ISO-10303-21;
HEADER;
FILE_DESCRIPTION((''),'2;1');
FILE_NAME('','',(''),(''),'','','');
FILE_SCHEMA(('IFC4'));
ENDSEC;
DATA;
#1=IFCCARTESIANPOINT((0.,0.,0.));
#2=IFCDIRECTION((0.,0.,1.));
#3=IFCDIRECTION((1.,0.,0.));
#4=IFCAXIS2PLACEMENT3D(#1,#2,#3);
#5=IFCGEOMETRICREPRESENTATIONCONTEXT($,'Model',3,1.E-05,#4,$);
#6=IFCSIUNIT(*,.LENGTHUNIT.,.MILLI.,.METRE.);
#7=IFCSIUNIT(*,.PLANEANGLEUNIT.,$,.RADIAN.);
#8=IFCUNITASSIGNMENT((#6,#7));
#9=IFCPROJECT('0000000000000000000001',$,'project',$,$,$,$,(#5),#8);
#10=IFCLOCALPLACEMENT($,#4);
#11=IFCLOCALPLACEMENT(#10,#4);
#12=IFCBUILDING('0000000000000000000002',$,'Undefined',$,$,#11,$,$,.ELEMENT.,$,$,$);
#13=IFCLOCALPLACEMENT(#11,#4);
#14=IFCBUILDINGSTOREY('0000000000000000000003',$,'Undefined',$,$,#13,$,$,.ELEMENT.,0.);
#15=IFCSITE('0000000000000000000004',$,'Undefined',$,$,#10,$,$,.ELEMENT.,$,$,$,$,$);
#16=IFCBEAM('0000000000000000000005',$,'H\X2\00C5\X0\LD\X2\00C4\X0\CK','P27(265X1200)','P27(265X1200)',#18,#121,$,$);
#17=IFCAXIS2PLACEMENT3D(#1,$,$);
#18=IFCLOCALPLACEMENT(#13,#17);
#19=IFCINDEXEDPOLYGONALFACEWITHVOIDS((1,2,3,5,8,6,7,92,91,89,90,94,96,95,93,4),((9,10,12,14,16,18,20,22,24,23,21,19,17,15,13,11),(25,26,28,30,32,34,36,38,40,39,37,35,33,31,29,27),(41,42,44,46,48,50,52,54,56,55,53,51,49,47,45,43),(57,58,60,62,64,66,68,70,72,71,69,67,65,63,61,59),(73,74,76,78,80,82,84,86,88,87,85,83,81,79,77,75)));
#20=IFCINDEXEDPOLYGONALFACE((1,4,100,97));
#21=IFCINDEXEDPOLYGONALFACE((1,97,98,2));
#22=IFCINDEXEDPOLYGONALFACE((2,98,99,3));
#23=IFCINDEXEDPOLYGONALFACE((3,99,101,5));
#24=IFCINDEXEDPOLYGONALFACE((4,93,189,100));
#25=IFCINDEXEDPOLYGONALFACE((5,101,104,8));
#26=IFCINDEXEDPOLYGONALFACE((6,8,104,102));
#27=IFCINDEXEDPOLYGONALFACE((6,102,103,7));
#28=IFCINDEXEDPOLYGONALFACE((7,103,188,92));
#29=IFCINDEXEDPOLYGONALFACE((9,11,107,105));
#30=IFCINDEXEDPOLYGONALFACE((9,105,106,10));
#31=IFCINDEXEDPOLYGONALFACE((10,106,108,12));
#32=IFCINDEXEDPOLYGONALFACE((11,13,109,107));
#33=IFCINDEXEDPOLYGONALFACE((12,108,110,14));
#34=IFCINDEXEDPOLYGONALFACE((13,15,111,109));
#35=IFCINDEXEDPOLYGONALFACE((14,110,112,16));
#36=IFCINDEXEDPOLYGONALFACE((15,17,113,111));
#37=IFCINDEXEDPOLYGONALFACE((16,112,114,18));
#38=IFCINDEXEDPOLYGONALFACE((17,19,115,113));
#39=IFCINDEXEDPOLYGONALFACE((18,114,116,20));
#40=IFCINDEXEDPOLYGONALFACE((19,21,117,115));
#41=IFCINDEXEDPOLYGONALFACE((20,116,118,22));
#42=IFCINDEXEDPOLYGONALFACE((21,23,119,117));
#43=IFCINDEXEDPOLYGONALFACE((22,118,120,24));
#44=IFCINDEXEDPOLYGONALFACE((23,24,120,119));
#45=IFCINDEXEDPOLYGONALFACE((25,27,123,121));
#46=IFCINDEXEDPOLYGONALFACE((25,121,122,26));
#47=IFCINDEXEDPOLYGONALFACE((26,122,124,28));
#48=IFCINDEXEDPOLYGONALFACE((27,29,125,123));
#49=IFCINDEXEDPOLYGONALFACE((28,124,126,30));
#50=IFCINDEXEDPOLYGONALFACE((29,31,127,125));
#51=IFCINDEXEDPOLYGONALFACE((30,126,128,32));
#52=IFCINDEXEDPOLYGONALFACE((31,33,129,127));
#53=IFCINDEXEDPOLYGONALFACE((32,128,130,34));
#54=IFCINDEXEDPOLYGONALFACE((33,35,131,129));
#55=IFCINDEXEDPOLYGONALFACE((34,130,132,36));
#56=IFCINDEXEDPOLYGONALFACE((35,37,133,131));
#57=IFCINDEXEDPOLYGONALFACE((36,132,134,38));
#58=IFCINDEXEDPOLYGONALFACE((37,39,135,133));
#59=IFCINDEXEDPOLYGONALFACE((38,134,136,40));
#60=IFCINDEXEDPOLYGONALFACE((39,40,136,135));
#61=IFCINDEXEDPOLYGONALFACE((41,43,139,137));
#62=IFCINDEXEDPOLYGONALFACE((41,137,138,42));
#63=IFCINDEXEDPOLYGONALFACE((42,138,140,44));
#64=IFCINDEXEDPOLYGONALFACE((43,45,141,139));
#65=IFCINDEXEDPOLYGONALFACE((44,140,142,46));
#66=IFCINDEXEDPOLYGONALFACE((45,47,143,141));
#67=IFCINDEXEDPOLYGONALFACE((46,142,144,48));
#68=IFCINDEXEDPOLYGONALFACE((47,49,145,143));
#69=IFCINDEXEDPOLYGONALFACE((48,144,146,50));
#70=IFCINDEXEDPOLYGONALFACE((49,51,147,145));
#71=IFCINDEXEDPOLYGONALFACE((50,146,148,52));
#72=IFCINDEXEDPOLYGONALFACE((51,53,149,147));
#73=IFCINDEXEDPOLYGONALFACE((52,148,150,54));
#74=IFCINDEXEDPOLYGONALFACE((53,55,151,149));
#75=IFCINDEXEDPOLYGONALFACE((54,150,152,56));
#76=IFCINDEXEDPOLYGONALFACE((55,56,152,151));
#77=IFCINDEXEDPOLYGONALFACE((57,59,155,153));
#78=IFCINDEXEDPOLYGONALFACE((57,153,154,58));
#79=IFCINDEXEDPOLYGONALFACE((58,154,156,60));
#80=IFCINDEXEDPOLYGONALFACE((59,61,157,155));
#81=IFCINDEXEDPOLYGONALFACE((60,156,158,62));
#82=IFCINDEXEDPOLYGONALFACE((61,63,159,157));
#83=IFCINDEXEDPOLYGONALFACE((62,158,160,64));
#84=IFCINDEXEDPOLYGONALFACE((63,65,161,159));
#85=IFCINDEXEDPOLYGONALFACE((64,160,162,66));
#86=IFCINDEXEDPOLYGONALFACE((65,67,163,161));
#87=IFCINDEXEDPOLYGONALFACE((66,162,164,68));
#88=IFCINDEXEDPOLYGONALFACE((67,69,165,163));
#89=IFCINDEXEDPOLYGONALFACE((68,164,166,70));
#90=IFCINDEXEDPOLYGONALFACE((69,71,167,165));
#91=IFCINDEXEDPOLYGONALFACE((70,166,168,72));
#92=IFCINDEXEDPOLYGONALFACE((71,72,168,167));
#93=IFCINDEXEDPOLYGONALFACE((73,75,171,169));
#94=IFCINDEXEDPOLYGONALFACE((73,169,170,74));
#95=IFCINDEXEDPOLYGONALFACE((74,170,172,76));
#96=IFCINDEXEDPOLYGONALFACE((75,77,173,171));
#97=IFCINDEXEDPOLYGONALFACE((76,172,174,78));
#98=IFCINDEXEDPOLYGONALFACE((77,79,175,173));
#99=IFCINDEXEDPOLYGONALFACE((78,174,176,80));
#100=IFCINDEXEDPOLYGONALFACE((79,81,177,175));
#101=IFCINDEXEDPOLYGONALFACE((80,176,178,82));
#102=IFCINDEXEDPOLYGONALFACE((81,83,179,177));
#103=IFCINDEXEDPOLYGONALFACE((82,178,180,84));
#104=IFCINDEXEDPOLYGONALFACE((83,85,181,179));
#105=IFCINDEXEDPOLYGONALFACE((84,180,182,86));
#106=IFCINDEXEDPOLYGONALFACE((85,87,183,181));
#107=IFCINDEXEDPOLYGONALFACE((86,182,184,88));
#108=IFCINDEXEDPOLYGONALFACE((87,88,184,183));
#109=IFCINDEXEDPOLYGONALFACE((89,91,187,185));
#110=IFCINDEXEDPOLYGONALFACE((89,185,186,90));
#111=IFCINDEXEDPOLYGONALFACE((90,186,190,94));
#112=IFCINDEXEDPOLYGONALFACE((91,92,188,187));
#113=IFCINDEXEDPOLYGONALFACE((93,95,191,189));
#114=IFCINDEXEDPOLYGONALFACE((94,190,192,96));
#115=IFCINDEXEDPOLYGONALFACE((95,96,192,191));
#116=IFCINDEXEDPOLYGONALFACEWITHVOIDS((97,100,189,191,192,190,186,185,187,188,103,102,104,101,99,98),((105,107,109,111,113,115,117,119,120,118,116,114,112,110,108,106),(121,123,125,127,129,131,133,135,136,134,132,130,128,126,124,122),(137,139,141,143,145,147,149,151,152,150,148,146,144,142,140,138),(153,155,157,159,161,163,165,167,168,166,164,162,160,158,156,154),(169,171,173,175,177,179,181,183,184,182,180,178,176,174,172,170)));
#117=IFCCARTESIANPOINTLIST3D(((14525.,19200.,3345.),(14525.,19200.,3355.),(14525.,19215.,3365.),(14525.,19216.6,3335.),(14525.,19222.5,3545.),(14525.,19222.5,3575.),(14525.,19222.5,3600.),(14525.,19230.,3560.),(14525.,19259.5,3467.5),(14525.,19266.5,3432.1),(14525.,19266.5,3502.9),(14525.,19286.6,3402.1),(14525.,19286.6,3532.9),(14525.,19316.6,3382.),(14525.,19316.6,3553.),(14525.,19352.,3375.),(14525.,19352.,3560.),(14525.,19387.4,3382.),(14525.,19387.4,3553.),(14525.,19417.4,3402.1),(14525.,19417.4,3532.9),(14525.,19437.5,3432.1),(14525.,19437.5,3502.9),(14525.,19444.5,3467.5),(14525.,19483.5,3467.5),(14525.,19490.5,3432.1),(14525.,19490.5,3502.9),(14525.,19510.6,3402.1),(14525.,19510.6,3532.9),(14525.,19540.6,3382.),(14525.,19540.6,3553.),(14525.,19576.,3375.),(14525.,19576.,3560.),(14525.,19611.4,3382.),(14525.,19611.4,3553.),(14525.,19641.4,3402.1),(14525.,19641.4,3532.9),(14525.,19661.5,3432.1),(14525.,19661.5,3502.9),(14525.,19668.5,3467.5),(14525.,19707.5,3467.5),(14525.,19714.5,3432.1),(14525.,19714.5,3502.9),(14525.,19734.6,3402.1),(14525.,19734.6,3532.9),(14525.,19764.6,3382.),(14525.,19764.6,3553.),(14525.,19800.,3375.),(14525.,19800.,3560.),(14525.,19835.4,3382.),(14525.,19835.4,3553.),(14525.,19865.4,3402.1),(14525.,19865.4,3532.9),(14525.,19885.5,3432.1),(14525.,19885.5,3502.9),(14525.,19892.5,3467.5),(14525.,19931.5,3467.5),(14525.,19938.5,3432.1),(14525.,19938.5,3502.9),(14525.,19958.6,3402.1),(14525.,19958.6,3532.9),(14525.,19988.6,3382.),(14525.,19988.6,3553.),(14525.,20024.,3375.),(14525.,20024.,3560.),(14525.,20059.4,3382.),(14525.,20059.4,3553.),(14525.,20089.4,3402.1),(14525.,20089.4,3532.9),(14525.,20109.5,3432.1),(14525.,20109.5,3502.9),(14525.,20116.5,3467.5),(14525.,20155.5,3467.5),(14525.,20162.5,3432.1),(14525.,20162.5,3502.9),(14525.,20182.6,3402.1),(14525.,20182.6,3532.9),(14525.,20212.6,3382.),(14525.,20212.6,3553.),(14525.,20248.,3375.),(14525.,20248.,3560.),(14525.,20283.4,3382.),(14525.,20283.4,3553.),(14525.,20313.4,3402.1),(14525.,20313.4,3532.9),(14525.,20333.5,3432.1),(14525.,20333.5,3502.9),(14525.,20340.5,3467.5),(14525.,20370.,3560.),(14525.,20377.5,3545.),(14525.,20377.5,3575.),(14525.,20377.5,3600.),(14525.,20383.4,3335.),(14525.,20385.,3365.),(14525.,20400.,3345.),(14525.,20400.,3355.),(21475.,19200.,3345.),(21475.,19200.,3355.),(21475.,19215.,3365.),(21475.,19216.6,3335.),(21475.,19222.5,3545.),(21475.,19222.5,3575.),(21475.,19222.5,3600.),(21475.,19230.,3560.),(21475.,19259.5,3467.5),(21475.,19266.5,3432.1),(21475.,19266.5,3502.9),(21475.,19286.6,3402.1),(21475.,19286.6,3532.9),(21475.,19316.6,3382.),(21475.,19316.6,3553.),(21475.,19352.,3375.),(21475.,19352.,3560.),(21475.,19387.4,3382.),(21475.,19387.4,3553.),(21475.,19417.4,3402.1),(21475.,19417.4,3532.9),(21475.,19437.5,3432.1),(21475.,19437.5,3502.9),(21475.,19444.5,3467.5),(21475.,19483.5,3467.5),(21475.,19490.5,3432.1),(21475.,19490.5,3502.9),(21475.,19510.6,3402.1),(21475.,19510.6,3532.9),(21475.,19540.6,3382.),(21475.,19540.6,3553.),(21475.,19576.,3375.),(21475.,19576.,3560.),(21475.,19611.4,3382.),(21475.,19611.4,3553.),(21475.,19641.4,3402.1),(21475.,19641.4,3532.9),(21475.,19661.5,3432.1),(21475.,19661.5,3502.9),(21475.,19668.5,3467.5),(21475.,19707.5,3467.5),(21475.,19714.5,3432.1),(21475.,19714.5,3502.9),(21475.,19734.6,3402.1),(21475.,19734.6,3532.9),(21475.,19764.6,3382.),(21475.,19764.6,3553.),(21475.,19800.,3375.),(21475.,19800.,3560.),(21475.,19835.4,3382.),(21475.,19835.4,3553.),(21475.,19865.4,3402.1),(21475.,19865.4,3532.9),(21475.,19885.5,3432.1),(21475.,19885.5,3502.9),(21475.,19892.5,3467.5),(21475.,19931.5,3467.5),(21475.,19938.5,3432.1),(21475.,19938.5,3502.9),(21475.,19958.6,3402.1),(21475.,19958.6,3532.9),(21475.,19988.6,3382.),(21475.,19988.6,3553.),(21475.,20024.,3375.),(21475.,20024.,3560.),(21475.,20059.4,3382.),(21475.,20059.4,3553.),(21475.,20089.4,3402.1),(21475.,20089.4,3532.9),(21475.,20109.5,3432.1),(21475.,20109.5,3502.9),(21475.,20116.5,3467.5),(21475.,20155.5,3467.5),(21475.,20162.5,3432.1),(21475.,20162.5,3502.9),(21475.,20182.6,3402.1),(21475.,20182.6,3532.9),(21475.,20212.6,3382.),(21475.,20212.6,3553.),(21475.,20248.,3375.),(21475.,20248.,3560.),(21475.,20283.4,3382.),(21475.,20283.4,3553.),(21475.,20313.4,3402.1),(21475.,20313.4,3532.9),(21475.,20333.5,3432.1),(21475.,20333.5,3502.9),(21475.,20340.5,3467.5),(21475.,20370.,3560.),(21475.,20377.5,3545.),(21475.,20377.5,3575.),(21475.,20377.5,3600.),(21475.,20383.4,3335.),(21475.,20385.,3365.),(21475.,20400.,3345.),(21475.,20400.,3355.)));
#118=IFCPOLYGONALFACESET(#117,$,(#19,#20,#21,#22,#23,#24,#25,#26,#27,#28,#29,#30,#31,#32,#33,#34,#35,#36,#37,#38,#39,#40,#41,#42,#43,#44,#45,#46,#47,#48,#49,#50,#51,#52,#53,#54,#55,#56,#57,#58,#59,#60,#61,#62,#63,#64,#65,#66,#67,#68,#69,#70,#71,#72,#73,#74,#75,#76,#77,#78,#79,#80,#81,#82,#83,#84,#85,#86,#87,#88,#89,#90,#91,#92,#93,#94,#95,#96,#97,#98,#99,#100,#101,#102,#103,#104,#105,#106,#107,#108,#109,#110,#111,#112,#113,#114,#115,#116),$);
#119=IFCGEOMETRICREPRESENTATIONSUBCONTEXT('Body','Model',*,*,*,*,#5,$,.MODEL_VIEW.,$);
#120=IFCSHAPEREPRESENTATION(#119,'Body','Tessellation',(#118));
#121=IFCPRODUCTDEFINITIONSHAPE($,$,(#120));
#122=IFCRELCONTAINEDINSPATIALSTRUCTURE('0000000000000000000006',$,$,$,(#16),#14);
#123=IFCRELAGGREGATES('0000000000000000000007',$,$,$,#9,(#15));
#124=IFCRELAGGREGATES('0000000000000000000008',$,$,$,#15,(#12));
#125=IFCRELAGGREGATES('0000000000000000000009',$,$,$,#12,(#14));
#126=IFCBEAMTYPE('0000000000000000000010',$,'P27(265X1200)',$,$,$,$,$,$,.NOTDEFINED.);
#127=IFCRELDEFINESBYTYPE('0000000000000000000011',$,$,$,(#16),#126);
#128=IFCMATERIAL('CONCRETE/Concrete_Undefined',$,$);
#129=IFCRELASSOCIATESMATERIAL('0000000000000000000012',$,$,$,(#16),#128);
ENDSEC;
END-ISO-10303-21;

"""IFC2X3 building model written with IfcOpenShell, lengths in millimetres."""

from ifc_helpers import new_model, si_unit, frame, origin_with_axes, place, context, subcontext, project, spatial, polyline, outline, extrude, material, type_object, element, save


model = new_model("IFC2X3")

# Units and contexts
model_context = context("Model", 3, precision=1e-05, world=origin_with_axes())
body_context = subcontext(model_context, "Body", "Model", "MODEL_VIEW")
ifc_project = project(units=[si_unit("LENGTHUNIT", "METRE", prefix="MILLI"), si_unit("PLANEANGLEUNIT", "RADIAN")], contexts=[model_context])

# Site, building, storey
site_placement = place(None, origin_with_axes())
site = spatial("IfcSite", under=ifc_project, at=site_placement, Name="Undefined", CompositionType="ELEMENT")
building_placement = place(site_placement, origin_with_axes())
building = spatial("IfcBuilding", under=site, at=building_placement, Name="Undefined", CompositionType="ELEMENT")
storey_placement = place(building_placement, origin_with_axes())
storey = spatial("IfcBuildingStorey", under=building, at=storey_placement, Name="Undefined", CompositionType="ELEMENT", Elevation=0.0)

# Beam
ifc_material_1 = material(Name="CONCRETE/Concrete_Undefined")
beam_type_1 = type_object("IfcBeamType", Name="P27(265X1200)", PredefinedType="NOTDEFINED")
beam_1_placement = place(storey_placement, frame((14525.0, 19800.0, 3467.5), z_axis=(0.0, 0.0, 1.0), x_axis=(1.0, 0.0, 0.0)))
element("IfcBeam", 1, at=beam_1_placement, inside=storey, type_object=beam_type_1, material=ifc_material_1, Name="HÅLDÄCK", Description="P27(265X1200)", ObjectType="P27(265X1200)", context=body_context, shape_type="SweptSolid", body=[
    extrude(outline(polyline([(-583.4, -132.5), (-600.0, -122.5), (-600.0, -112.5), (-585.0, -102.5), (-577.5, 77.5), (-570.0, 92.5), (-577.5, 107.5), (-577.5, 132.5), (577.5, 132.5), (577.5, 107.5), (570.0, 92.5), (577.5, 77.5), (585.0, -102.5), (600.0, -112.5), (600.0, -122.5), (583.4, -132.5), (-583.4, -132.5)]), holes=[polyline([(-513.4, 65.4), (-533.5, 35.4), (-540.5, 0.0), (-533.5, -35.4), (-513.4, -65.4), (-483.4, -85.5), (-448.0, -92.5), (-412.6, -85.5), (-382.6, -65.4), (-362.5, -35.4), (-355.5, 0.0), (-362.5, 35.4), (-382.6, 65.4), (-412.6, 85.5), (-448.0, 92.5), (-483.4, 85.5), (-513.4, 65.4)]), polyline([(-289.4, 65.4), (-309.5, 35.4), (-316.5, 0.0), (-309.5, -35.4), (-289.4, -65.4), (-259.4, -85.5), (-224.0, -92.5), (-188.6, -85.5), (-158.6, -65.4), (-138.5, -35.4), (-131.5, 0.0), (-138.5, 35.4), (-158.6, 65.4), (-188.6, 85.5), (-224.0, 92.5), (-259.4, 85.5), (-289.4, 65.4)]), polyline([(-65.4, 65.4), (-85.5, 35.4), (-92.5, 0.0), (-85.5, -35.4), (-65.4, -65.4), (-35.4, -85.5), (0.0, -92.5), (35.4, -85.5), (65.4, -65.4), (85.5, -35.4), (92.5, 0.0), (85.5, 35.4), (65.4, 65.4), (35.4, 85.5), (0.0, 92.5), (-35.4, 85.5), (-65.4, 65.4)]), polyline([(158.6, 65.4), (138.5, 35.4), (131.5, 0.0), (138.5, -35.4), (158.6, -65.4), (188.6, -85.5), (224.0, -92.5), (259.4, -85.5), (289.4, -65.4), (309.5, -35.4), (316.5, 0.0), (309.5, 35.4), (289.4, 65.4), (259.4, 85.5), (224.0, 92.5), (188.6, 85.5), (158.6, 65.4)]), polyline([(382.6, 65.4), (362.5, 35.4), (355.5, 0.0), (362.5, -35.4), (382.6, -65.4), (412.6, -85.5), (448.0, -92.5), (483.4, -85.5), (513.4, -65.4), (533.5, -35.4), (540.5, 0.0), (533.5, 35.4), (513.4, 65.4), (483.4, 85.5), (448.0, 92.5), (412.6, 85.5), (382.6, 65.4)])]), frame((6950.0, 0.0, 0.0), z_axis=(-1.0, 0.0, 0.0), x_axis=(0.0, -1.0, 0.0)), (0.0, 0.0, 1.0), 6950.0),
])

save(model, "model.ifc")
